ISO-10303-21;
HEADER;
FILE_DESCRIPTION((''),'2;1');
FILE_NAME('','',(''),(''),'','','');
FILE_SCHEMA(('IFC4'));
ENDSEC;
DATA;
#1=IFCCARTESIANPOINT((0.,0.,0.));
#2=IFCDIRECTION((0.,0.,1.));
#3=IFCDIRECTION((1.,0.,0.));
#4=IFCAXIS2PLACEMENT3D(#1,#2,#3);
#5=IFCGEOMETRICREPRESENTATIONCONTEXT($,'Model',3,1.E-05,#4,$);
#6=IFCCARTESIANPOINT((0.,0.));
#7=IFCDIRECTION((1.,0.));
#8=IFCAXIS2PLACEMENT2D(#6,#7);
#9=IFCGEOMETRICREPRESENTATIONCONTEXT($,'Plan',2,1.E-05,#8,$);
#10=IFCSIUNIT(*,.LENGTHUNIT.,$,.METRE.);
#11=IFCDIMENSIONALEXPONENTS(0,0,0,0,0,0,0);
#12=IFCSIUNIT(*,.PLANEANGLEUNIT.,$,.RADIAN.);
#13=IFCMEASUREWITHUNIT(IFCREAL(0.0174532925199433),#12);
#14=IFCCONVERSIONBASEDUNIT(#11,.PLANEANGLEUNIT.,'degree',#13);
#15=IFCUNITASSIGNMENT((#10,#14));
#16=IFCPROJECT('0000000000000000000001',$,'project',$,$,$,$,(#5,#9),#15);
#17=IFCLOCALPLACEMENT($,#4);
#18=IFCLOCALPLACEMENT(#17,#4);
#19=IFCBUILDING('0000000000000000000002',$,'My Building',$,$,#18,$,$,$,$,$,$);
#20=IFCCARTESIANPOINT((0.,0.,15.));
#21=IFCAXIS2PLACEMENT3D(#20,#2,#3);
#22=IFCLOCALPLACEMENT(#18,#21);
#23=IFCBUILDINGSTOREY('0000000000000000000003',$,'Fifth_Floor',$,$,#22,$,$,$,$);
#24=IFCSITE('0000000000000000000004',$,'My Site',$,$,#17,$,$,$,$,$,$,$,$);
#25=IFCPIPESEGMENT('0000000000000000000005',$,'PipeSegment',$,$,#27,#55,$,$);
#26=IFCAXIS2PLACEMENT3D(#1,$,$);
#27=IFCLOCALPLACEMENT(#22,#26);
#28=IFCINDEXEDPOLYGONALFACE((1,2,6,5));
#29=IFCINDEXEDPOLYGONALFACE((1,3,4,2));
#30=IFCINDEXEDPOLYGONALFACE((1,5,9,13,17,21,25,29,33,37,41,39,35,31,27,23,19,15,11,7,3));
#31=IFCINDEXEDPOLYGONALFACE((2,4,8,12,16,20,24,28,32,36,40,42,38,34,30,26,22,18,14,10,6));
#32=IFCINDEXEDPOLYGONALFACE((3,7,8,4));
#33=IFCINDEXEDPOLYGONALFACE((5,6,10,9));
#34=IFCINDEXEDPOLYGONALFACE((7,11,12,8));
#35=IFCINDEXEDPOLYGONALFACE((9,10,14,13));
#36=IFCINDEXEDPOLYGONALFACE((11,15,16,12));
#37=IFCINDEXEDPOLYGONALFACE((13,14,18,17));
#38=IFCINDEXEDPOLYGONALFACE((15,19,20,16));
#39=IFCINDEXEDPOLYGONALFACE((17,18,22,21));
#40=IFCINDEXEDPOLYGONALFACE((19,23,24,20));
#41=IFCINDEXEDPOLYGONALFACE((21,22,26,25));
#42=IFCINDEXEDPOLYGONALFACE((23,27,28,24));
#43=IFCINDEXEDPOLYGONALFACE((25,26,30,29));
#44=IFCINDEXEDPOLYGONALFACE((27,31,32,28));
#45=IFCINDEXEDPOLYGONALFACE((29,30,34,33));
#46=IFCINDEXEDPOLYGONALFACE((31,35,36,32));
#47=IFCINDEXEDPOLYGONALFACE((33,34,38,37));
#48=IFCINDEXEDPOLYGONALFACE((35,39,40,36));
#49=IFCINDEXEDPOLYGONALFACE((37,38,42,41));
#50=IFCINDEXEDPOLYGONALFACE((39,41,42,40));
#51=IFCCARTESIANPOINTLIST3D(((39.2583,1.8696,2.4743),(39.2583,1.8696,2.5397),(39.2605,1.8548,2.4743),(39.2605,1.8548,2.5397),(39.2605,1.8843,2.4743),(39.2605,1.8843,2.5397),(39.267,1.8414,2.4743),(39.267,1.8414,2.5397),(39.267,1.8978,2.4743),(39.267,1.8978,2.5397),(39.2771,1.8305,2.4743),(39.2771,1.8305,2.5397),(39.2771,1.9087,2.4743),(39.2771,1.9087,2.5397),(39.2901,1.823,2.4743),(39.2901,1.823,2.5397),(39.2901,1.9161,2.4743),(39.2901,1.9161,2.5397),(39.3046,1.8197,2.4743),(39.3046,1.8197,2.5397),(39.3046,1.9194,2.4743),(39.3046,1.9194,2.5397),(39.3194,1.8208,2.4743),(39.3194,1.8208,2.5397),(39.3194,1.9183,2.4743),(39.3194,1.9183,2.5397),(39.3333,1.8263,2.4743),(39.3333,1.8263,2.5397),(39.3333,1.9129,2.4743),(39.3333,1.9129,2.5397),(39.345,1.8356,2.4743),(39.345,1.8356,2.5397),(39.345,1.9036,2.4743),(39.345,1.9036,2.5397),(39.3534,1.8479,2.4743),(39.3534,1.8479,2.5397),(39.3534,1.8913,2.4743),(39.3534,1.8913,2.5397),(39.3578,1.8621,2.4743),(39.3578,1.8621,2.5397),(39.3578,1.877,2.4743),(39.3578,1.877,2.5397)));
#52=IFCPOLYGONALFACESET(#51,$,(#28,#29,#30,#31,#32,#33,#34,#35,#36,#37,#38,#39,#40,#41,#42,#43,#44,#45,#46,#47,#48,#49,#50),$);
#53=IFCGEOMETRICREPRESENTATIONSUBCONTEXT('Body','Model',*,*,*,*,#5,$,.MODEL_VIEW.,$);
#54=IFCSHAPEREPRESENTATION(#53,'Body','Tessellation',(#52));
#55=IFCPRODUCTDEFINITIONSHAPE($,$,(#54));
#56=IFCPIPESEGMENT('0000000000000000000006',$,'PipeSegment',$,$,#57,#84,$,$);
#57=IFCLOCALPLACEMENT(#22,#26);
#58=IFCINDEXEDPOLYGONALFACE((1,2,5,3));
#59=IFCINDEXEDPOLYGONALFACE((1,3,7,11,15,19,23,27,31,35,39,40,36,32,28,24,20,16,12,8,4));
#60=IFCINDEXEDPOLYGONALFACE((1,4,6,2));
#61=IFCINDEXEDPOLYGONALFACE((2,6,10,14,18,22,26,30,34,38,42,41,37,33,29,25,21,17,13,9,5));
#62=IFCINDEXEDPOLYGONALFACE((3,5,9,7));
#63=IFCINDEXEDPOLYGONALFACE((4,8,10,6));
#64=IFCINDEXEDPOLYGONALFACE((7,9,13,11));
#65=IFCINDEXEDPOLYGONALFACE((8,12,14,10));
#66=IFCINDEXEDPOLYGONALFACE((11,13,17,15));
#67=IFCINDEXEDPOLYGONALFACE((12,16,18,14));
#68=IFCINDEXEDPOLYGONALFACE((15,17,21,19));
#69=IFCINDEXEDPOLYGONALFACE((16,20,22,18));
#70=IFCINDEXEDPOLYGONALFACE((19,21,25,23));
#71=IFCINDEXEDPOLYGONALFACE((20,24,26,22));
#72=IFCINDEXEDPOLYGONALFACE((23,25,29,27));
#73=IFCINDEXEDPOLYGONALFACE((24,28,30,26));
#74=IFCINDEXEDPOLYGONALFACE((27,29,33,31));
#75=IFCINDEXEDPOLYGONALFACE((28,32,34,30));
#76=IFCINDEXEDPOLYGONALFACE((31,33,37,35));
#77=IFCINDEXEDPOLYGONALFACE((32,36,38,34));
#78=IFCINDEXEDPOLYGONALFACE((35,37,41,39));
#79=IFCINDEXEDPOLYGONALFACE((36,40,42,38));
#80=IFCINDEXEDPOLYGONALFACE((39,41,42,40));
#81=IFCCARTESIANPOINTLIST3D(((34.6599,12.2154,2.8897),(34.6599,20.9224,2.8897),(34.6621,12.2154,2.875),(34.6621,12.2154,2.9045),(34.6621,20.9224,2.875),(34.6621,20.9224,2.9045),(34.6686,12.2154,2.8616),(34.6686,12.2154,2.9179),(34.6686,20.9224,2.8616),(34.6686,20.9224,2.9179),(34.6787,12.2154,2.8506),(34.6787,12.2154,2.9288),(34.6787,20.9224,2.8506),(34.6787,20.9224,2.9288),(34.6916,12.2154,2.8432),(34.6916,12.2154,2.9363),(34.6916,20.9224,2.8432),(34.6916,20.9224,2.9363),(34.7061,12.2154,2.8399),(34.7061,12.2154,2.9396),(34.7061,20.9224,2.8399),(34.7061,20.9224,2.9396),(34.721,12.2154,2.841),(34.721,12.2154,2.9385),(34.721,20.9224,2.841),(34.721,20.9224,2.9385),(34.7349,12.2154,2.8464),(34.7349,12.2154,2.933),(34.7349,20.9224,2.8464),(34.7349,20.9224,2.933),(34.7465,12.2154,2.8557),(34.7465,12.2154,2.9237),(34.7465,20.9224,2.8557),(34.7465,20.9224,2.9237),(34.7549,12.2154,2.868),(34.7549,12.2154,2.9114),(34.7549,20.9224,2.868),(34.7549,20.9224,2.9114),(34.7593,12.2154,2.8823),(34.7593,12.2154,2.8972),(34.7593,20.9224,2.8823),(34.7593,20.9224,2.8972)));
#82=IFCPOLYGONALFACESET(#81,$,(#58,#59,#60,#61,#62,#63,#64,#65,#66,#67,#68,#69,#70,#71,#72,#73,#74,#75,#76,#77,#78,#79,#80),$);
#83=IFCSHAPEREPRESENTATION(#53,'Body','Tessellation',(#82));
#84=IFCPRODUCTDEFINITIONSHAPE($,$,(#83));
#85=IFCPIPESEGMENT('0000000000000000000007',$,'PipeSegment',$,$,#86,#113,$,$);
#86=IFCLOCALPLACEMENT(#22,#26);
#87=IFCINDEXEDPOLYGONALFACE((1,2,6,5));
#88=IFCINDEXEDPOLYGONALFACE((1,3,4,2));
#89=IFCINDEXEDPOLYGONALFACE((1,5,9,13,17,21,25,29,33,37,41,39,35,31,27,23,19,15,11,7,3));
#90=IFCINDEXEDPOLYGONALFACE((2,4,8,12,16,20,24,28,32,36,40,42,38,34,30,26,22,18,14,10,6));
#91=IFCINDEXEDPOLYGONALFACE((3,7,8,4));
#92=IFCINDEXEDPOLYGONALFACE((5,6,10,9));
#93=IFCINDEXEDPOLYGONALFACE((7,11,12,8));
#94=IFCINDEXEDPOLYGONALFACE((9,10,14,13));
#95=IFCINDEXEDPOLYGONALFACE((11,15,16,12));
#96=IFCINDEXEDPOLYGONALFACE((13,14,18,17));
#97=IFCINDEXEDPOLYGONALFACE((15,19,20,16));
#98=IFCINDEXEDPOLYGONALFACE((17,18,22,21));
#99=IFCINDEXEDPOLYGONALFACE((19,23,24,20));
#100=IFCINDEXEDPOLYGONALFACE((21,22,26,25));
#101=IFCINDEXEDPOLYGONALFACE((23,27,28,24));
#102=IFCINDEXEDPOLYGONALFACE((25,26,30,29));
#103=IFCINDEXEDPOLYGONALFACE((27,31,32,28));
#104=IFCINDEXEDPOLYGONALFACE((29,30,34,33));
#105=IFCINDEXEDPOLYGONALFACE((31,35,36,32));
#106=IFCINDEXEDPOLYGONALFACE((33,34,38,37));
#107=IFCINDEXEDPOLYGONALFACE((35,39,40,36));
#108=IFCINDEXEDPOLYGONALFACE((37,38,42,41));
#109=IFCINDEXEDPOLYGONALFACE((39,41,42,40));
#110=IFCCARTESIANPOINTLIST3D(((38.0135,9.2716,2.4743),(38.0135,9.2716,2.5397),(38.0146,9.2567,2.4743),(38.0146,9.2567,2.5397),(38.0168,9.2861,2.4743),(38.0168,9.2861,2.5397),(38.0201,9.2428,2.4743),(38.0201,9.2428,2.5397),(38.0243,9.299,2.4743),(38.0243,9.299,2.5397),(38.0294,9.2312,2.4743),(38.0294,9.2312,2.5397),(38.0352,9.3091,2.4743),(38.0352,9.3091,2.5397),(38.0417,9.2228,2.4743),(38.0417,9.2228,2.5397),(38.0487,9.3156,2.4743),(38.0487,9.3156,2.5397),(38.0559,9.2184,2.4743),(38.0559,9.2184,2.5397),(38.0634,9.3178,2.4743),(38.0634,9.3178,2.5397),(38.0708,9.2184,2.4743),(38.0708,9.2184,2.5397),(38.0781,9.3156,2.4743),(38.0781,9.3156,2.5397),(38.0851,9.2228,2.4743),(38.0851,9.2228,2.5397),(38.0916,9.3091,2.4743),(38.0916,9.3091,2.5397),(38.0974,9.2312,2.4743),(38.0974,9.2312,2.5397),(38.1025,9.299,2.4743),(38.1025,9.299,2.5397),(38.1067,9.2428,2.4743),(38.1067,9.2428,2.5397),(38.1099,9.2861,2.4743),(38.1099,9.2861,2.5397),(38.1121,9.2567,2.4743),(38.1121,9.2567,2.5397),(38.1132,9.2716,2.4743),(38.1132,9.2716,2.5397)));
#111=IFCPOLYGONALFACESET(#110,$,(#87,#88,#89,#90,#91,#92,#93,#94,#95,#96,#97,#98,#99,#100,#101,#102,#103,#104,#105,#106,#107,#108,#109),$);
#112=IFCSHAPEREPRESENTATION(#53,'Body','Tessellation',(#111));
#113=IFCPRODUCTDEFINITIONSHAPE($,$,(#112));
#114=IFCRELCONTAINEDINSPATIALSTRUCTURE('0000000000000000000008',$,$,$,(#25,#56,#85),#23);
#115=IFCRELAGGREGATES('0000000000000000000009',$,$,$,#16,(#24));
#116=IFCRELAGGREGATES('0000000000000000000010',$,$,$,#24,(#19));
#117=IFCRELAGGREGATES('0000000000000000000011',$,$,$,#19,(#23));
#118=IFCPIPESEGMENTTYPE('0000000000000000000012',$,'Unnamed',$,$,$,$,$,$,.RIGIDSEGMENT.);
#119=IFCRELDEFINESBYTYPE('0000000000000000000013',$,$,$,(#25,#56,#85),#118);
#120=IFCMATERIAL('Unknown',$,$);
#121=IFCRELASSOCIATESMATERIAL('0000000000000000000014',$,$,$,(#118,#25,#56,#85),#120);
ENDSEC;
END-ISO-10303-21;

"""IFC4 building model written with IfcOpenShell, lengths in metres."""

from ifc_helpers import new_model, entity, si_unit, converted_unit, frame, origin_with_axes, origin_2d_with_axis, place, context, subcontext, project, spatial, circle, extrude, material, material_profile, profile_set, profile_usage, type_object, element, save


model = new_model("IFC4")

# Units and contexts
model_context = context("Model", 3, precision=1e-05, world=origin_with_axes())
plan_context = context("Plan", 2, precision=1e-05, world=origin_2d_with_axis())
body_context_1 = subcontext(model_context, "Body", "Model", "MODEL_VIEW")
ifc_project = project(units=[si_unit("LENGTHUNIT", "METRE"), converted_unit("PLANEANGLEUNIT", "degree", entity("IfcReal", 0.0174532925199433), si_unit("PLANEANGLEUNIT", "RADIAN"), dimensions=[0, 0, 0, 0, 0, 0, 0])], contexts=[model_context, plan_context])

# Site, building, storey
site_placement = place(None, origin_with_axes())
site = spatial("IfcSite", under=ifc_project, at=site_placement, Name="My Site")
building_placement = place(site_placement, origin_with_axes())
building = spatial("IfcBuilding", under=site, at=building_placement, Name="My Building")
storey_placement = place(building_placement, frame((0.0, 0.0, 15.0), z_axis=(0.0, 0.0, 1.0), x_axis=(1.0, 0.0, 0.0)))
storey = spatial("IfcBuildingStorey", under=building, at=storey_placement, Name="Fifth_Floor")

# Shared definitions
ifc_material = material(Name="Unknown")

# Pipe segments
ifc_material_profile_1 = material_profile(ifc_material, circle(Radius=0.05))
ifc_profile_set_1 = profile_set([ifc_material_profile_1])
pipe_segment_type = type_object("IfcPipeSegmentType", Name="Unnamed", PredefinedType="RIGIDSEGMENT", material=ifc_profile_set_1)
ifc_profile_usage_1 = profile_usage(ifc_profile_set_1, cardinal=5)
pipe_segment_1_placement = place(storey_placement, frame((39.3083, 1.8696, 2.4743), z_axis=(0.0, 0.0, 1.0), x_axis=(-1.0, 0.0, 0.0)))
element("IfcPipeSegment", 1, at=pipe_segment_1_placement, inside=storey, type_object=pipe_segment_type, material=ifc_profile_usage_1, Name="PipeSegment", context=body_context_1, shape_type="SweptSolid", body=[
    extrude(circle(Radius=0.05), origin_with_axes(), (0.0, 0.0, 1.0), 0.0654),
])
ifc_profile_usage_2 = profile_usage(ifc_profile_set_1, cardinal=5)
pipe_segment_2_placement = place(storey_placement, frame((34.7099, 12.2154, 2.8897), z_axis=(0.0, 1.0, 0.0), x_axis=(-1.0, 0.0, 0.0)))
element("IfcPipeSegment", 2, at=pipe_segment_2_placement, inside=storey, type_object=pipe_segment_type, material=ifc_profile_usage_2, Name="PipeSegment", context=body_context_1, shape_type="SweptSolid", body=[
    extrude(circle(Radius=0.05), origin_with_axes(), (0.0, 0.0, 1.0), 8.707),
])
ifc_profile_usage_3 = profile_usage(ifc_profile_set_1, cardinal=5)
pipe_segment_3_placement = place(storey_placement, frame((38.0634, 9.2678, 2.4743), z_axis=(0.0, 0.0, 1.0), x_axis=(-0.000001, 1.0, 0.0)))
element("IfcPipeSegment", 3, at=pipe_segment_3_placement, inside=storey, type_object=pipe_segment_type, material=ifc_profile_usage_3, Name="PipeSegment", context=body_context_1, shape_type="SweptSolid", body=[
    extrude(circle(Radius=0.05), origin_with_axes(), (0.0, 0.0, 1.0), 0.0654),
])

save(model, "model.ifc")
